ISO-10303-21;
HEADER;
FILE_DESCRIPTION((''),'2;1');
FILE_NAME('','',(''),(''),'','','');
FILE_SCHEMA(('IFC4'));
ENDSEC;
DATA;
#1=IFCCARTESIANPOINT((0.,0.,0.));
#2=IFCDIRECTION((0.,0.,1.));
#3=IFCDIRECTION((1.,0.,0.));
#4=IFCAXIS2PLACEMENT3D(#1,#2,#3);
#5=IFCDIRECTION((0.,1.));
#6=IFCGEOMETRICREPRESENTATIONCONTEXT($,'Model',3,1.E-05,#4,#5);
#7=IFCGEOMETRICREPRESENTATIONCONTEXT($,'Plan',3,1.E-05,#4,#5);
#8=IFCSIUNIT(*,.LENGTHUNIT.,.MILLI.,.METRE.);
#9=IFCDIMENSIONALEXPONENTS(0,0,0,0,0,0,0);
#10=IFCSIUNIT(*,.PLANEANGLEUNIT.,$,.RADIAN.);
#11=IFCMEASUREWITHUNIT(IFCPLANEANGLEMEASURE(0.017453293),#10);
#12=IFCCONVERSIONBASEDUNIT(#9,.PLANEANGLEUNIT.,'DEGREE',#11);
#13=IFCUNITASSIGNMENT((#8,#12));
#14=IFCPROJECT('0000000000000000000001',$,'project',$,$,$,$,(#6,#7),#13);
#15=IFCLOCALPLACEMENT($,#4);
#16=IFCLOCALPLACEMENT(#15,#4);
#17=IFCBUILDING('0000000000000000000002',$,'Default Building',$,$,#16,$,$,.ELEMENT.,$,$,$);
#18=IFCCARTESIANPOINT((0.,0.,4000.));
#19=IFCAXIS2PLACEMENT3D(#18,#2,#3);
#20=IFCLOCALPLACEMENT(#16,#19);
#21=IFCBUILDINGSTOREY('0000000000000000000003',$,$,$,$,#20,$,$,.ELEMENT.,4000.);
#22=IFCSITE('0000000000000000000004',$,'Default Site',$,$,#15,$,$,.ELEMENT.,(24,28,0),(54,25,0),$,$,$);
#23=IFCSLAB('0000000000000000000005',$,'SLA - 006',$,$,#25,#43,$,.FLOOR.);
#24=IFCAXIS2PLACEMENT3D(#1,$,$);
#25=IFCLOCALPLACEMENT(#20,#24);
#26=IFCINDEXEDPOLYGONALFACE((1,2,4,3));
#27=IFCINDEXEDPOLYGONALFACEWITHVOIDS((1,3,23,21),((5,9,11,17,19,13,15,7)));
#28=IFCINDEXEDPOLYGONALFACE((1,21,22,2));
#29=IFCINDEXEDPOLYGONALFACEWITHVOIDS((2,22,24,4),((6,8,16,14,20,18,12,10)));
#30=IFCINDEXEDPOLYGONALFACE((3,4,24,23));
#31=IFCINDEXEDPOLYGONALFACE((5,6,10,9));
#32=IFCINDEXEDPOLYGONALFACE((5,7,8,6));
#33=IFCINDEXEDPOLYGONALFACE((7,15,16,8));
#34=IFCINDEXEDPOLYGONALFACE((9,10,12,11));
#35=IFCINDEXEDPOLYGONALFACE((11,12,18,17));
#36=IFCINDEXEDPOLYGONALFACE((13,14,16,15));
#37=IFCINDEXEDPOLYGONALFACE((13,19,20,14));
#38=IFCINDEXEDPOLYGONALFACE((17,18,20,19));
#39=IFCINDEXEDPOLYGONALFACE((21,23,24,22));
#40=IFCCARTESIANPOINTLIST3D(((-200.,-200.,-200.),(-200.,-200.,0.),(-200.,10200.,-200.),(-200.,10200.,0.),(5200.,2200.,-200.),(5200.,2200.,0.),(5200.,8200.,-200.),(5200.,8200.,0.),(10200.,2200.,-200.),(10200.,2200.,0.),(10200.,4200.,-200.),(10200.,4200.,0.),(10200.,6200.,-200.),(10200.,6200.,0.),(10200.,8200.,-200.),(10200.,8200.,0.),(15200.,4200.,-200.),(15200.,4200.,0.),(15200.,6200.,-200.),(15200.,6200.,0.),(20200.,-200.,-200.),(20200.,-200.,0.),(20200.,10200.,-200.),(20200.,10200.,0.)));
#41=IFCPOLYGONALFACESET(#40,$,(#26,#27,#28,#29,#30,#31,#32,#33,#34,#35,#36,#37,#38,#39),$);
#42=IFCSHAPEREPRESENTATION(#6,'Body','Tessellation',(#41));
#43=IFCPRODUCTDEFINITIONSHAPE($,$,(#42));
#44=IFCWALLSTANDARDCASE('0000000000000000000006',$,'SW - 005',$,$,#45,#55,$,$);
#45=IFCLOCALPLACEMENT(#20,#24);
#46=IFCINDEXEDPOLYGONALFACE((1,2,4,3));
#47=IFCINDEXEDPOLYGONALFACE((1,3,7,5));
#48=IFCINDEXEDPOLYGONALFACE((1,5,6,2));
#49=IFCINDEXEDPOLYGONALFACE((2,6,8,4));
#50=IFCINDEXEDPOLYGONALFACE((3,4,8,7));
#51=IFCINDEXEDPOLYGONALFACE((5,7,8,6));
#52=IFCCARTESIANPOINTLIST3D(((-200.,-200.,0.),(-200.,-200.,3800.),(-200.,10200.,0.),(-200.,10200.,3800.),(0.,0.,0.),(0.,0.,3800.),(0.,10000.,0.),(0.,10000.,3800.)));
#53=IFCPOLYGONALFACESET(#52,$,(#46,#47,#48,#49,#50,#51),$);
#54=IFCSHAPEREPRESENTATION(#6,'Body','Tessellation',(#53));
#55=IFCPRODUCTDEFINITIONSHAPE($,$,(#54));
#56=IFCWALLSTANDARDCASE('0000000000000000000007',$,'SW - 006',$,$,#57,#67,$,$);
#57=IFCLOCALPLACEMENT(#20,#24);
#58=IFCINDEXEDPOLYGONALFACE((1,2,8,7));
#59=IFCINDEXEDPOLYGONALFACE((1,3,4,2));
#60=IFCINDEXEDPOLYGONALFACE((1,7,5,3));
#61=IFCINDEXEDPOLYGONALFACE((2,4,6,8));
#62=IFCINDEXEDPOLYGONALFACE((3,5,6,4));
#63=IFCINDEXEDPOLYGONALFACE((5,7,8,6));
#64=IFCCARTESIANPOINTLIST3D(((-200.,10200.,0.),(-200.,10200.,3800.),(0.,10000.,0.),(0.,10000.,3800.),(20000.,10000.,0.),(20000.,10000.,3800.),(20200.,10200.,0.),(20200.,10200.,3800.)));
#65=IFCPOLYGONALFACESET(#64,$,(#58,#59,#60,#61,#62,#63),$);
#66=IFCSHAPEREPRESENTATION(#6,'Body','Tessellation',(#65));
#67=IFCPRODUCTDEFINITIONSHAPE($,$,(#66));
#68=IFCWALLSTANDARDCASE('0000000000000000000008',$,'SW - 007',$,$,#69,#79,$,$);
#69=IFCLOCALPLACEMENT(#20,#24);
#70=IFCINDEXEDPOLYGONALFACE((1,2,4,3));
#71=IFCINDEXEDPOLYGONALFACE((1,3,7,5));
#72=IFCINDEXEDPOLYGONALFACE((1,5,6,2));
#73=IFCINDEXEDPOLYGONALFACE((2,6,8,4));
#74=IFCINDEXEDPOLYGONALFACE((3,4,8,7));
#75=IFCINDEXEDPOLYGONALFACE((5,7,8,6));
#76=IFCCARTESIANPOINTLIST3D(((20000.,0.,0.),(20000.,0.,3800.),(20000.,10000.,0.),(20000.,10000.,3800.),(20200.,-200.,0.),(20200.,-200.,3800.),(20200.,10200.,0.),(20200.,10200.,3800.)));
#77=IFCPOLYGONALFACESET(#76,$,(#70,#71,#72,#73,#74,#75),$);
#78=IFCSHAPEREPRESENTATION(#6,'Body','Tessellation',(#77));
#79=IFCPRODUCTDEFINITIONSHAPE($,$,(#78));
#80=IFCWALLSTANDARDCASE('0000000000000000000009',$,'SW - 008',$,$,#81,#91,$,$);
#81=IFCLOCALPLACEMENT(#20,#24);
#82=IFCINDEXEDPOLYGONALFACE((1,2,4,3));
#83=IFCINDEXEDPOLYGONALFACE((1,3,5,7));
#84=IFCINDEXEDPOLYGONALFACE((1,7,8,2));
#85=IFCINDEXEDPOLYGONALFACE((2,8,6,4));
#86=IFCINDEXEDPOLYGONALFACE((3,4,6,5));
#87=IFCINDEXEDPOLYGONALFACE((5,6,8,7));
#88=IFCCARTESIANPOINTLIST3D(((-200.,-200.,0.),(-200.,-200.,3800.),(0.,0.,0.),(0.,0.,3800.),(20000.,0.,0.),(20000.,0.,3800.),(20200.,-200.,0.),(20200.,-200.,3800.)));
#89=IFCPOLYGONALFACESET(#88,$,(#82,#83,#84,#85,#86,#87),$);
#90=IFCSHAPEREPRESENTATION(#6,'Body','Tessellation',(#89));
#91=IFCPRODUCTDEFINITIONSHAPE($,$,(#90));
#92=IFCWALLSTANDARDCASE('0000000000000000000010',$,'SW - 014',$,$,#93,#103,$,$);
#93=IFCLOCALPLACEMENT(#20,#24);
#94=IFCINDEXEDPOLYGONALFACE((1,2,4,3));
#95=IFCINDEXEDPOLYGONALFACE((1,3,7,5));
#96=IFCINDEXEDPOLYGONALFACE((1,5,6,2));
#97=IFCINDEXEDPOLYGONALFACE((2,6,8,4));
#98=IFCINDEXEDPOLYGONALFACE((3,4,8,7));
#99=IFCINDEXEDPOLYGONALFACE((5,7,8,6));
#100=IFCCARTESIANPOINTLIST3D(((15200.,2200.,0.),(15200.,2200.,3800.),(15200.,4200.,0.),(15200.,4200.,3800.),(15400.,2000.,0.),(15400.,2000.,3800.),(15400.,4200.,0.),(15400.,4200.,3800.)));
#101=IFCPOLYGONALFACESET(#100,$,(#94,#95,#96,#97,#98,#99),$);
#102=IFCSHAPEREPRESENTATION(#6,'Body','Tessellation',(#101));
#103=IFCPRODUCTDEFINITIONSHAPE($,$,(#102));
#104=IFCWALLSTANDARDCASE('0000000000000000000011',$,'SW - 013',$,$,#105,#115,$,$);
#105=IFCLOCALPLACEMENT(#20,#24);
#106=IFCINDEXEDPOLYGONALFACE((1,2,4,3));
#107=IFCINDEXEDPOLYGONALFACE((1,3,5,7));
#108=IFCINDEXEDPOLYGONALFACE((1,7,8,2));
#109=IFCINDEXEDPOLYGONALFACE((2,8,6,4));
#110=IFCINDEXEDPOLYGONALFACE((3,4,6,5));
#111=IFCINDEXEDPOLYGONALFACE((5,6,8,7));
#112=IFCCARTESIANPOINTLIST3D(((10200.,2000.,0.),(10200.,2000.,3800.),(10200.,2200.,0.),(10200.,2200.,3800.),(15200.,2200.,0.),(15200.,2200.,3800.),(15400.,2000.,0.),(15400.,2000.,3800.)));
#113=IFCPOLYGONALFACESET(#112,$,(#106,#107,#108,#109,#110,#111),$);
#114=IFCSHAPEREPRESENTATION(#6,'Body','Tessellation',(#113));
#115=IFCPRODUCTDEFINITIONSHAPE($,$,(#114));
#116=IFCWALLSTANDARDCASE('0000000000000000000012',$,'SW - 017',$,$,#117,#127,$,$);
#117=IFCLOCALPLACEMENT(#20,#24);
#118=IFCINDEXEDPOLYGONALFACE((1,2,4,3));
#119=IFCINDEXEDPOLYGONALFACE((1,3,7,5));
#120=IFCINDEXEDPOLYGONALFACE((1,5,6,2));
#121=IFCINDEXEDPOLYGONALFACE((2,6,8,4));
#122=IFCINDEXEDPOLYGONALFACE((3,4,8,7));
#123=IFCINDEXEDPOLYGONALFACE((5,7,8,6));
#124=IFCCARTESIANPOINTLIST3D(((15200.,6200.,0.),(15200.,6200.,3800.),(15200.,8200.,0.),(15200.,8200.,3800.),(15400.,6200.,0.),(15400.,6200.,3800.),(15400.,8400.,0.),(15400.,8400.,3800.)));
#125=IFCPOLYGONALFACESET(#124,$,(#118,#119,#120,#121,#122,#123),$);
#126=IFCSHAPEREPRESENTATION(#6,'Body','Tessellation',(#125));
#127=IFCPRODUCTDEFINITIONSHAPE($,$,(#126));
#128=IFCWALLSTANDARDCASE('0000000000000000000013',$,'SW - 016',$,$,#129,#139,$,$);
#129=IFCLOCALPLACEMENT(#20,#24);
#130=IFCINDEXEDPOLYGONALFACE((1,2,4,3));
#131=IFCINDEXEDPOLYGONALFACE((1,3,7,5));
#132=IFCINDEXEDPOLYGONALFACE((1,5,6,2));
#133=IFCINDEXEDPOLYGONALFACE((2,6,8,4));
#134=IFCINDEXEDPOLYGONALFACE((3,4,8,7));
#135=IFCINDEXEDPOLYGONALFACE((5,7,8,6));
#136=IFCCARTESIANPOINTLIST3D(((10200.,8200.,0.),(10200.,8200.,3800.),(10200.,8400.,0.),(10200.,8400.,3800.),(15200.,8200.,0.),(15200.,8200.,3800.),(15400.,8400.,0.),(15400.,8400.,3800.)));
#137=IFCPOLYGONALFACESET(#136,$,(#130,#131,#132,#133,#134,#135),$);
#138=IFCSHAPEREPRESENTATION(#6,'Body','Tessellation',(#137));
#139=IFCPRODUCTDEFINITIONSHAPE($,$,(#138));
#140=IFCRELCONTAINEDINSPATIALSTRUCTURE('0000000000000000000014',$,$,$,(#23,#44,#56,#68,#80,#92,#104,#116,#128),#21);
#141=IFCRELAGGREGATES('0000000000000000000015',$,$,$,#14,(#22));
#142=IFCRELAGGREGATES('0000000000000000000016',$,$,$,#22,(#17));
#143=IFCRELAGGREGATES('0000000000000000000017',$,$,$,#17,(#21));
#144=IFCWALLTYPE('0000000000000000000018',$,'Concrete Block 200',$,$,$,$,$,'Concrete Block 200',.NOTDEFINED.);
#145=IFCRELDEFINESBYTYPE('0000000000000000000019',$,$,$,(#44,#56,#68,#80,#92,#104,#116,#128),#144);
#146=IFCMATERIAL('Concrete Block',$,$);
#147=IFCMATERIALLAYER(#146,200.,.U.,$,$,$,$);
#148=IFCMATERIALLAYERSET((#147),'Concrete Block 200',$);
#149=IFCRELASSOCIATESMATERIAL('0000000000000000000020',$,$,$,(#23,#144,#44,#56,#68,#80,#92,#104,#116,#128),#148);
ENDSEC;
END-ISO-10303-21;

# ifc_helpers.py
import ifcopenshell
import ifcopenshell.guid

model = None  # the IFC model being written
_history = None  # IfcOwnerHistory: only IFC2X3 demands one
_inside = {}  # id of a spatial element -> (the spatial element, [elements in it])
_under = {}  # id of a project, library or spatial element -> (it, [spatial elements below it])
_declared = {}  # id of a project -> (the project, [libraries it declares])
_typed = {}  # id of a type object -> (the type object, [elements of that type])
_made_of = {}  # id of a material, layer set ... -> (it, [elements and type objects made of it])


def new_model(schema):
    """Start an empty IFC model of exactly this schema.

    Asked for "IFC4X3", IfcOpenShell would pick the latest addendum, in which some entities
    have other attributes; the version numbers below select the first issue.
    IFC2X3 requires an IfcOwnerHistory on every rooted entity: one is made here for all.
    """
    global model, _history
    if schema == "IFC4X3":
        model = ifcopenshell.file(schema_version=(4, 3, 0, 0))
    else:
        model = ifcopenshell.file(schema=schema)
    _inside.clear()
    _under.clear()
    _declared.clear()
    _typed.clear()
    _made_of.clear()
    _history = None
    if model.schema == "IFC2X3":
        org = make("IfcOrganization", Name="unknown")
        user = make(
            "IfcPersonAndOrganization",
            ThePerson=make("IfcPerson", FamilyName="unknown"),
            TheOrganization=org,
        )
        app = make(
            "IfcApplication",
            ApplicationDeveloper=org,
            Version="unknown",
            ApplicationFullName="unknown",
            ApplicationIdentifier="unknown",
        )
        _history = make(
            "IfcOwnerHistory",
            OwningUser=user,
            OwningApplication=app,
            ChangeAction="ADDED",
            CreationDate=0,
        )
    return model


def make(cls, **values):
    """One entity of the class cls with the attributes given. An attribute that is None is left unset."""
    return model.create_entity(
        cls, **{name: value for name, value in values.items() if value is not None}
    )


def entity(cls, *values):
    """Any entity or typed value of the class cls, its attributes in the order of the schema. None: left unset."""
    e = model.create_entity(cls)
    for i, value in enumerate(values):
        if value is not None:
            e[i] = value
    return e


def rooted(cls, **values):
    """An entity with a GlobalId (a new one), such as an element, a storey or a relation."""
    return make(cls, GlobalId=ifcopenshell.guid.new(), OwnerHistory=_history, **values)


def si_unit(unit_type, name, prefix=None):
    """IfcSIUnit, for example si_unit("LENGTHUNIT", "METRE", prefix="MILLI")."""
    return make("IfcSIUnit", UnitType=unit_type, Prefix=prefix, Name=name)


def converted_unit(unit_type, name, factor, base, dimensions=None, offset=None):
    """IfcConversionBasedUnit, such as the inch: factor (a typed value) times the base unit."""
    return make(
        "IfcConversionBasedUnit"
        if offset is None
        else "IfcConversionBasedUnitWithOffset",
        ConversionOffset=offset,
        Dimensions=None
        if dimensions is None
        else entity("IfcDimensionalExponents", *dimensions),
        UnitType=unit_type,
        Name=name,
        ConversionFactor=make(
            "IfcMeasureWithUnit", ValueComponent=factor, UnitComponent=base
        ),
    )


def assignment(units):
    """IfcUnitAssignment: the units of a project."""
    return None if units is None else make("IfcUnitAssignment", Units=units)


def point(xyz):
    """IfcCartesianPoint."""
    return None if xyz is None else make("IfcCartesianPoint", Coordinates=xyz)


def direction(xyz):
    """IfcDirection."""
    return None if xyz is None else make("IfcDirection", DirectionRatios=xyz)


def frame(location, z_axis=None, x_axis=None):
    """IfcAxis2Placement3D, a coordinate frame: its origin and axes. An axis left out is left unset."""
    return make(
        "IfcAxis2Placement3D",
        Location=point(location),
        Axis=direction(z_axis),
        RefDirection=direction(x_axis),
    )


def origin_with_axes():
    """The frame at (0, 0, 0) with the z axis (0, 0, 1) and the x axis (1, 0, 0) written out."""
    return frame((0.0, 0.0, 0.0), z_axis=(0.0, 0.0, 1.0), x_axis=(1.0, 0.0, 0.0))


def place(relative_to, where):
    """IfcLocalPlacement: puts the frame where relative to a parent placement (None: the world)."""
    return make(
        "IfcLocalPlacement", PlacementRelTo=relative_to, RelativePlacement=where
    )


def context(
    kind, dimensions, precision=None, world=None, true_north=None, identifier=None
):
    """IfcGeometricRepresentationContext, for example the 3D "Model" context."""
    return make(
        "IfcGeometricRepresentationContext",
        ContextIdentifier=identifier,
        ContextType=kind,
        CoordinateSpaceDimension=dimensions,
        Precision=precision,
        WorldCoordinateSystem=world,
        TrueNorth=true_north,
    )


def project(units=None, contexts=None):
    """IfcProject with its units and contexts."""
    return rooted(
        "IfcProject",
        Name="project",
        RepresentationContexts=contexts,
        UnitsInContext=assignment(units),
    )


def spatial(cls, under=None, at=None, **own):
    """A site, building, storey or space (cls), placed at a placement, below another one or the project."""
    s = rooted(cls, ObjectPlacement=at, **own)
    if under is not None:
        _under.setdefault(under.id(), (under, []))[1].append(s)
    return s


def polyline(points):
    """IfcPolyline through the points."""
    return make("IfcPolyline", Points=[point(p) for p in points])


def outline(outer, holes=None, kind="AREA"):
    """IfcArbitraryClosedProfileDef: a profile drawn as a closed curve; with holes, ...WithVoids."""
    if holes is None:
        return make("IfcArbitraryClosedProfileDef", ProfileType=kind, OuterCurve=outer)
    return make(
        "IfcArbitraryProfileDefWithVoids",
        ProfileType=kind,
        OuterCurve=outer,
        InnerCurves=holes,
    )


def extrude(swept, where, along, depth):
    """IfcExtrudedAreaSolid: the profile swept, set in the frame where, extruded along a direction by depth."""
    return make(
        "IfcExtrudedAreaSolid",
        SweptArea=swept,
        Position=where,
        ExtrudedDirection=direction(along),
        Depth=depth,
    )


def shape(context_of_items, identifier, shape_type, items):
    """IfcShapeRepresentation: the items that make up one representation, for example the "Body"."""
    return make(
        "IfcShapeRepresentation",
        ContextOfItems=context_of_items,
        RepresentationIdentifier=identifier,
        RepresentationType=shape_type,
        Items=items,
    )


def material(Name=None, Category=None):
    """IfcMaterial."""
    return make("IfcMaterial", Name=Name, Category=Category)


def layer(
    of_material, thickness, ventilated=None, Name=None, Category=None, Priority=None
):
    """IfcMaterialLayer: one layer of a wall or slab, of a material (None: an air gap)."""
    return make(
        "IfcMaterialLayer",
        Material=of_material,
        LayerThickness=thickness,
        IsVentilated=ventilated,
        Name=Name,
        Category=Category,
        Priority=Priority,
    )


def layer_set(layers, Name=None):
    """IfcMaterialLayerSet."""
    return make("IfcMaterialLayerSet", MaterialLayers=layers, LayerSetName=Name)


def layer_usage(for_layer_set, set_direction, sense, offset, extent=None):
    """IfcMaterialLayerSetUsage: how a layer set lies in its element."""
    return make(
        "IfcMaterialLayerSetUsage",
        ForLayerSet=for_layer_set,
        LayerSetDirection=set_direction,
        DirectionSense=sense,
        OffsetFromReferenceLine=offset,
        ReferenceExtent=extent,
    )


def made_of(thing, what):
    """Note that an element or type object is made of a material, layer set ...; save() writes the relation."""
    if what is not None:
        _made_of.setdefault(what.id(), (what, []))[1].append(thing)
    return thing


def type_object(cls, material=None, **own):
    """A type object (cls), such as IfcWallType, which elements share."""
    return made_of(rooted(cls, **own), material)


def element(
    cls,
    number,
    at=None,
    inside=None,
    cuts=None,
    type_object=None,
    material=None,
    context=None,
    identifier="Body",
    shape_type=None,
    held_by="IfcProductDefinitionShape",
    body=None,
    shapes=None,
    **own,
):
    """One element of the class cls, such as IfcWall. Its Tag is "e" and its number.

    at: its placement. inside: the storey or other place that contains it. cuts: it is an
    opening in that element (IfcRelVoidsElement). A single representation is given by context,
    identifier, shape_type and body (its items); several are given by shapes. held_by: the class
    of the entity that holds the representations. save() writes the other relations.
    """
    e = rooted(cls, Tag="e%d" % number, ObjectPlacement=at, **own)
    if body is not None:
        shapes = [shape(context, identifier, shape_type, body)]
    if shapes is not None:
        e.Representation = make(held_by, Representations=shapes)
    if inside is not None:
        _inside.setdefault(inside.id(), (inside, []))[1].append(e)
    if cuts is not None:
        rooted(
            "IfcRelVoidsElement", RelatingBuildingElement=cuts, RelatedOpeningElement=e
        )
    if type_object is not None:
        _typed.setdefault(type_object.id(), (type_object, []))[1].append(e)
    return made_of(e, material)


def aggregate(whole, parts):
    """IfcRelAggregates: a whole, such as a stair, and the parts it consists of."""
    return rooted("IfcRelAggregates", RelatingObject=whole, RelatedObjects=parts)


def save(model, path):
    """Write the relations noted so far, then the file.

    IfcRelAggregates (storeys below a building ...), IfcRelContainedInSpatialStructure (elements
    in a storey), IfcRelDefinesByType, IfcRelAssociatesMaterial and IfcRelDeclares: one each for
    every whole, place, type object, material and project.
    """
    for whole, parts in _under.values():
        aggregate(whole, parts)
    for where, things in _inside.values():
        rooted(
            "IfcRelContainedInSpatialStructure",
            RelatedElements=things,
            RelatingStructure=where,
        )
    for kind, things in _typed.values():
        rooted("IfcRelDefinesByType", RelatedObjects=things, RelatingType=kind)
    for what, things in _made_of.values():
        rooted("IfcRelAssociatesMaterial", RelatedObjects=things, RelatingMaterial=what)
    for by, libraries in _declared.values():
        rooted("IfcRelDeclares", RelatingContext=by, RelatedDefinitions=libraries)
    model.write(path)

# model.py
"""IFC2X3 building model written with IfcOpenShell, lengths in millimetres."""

from ifc_helpers import new_model, entity, si_unit, converted_unit, direction, frame, origin_with_axes, place, context, project, spatial, polyline, outline, extrude, material, layer, layer_set, layer_usage, type_object, element, save


model = new_model("IFC2X3")

# Units and contexts
model_context = context("Model", 3, precision=1e-05, world=origin_with_axes(), true_north=direction((0.0, 1.0)))
plan_context = context("Plan", 3, precision=1e-05, world=origin_with_axes(), true_north=direction((0.0, 1.0)))
ifc_project = project(units=[si_unit("LENGTHUNIT", "METRE", prefix="MILLI"), converted_unit("PLANEANGLEUNIT", "DEGREE", entity("IfcPlaneAngleMeasure", 0.017453293), si_unit("PLANEANGLEUNIT", "RADIAN"), dimensions=[0, 0, 0, 0, 0, 0, 0])], contexts=[model_context, plan_context])

# Site, building, storey
site_placement = place(None, origin_with_axes())
site = spatial("IfcSite", under=ifc_project, at=site_placement, Name="Default Site", CompositionType="ELEMENT", RefLatitude=(24, 28, 0), RefLongitude=(54, 25, 0))
building_placement = place(site_placement, origin_with_axes())
building = spatial("IfcBuilding", under=site, at=building_placement, Name="Default Building", CompositionType="ELEMENT")
storey_placement = place(building_placement, frame((0.0, 0.0, 4000.0), z_axis=(0.0, 0.0, 1.0), x_axis=(1.0, 0.0, 0.0)))
storey = spatial("IfcBuildingStorey", under=building, at=storey_placement, CompositionType="ELEMENT", Elevation=4000.0)

# Slab, opening
ifc_material = material(Name="Concrete Block")
ifc_layer = layer(ifc_material, 200.0, ventilated="UNKNOWN")
ifc_layer_set = layer_set([ifc_layer], Name="Concrete Block 200")
ifc_layer_usage_1 = layer_usage(ifc_layer_set, "AXIS3", "NEGATIVE", 200.0)
slab_placement = place(storey_placement, frame((20200.0, 10200.0, -200.0), z_axis=(0.0, 0.0, 1.0), x_axis=(-1.0, 0.0, 0.0)))
slab = element("IfcSlab", 1, at=slab_placement, inside=storey, material=ifc_layer_usage_1, Name="SLA - 006", PredefinedType="FLOOR", context=model_context, shape_type="SweptSolid", body=[
    extrude(outline(polyline([(0.0, 0.0), (20400.0, 0.0), (20400.0, 10400.0), (0.0, 10400.0), (0.0, 0.0)])), origin_with_axes(), (0.0, 0.0, 1.0), 200.0),
])
opening_placement = place(slab_placement, origin_with_axes())
element("IfcOpeningElement", 2, at=opening_placement, cuts=slab, context=model_context, shape_type="SweptSolid", body=[
    extrude(outline(polyline([(10000.0, 8000.0), (15000.0, 8000.0), (15000.0, 2000.0), (10000.0, 2000.0), (10000.0, 4000.0), (5000.0, 4000.0), (5000.0, 6000.0), (10000.0, 6000.0), (10000.0, 8000.0)])), origin_with_axes(), (0.0, 0.0, 1.0), 200.0),
])

# Walls
ifc_layer_usage_2 = layer_usage(ifc_layer_set, "AXIS2", "POSITIVE", 0.0)
wall_type = type_object("IfcWallType", Name="Concrete Block 200", ElementType="Concrete Block 200", PredefinedType="NOTDEFINED", material=ifc_layer_set)
wall_1_placement = place(storey_placement, frame((0.0, 0.0, 0.0), z_axis=(0.0, 0.0, 1.0), x_axis=(0.0, 1.0, 0.0)))
element("IfcWallStandardCase", 3, at=wall_1_placement, inside=storey, type_object=wall_type, material=ifc_layer_usage_2, Name="SW - 005", context=model_context, shape_type="SweptSolid", body=[
    extrude(outline(polyline([(0.0, 0.0), (10000.0, 0.0), (10200.0, 200.0), (-200.0, 200.0), (0.0, 0.0)])), origin_with_axes(), (0.0, 0.0, 1.0), 3800.0),
])
ifc_layer_usage_3 = layer_usage(ifc_layer_set, "AXIS2", "POSITIVE", 0.0)
wall_2_placement = place(storey_placement, frame((0.0, 10000.0, 0.0), z_axis=(0.0, 0.0, 1.0), x_axis=(1.0, 0.0, 0.0)))
element("IfcWallStandardCase", 4, at=wall_2_placement, inside=storey, type_object=wall_type, material=ifc_layer_usage_3, Name="SW - 006", context=model_context, shape_type="SweptSolid", body=[
    extrude(outline(polyline([(0.0, 0.0), (20000.0, 0.0), (20200.0, 200.0), (-200.0, 200.0), (0.0, 0.0)])), origin_with_axes(), (0.0, 0.0, 1.0), 3800.0),
])
ifc_layer_usage_4 = layer_usage(ifc_layer_set, "AXIS2", "POSITIVE", 0.0)
wall_3_placement = place(storey_placement, frame((20000.0, 10000.0, 0.0), z_axis=(0.0, 0.0, 1.0), x_axis=(0.0, -1.0, 0.0)))
element("IfcWallStandardCase", 5, at=wall_3_placement, inside=storey, type_object=wall_type, material=ifc_layer_usage_4, Name="SW - 007", context=model_context, shape_type="SweptSolid", body=[
    extrude(outline(polyline([(0.0, 0.0), (10000.0, 0.0), (10200.0, 200.0), (-200.0, 200.0), (0.0, 0.0)])), origin_with_axes(), (0.0, 0.0, 1.0), 3800.0),
])
ifc_layer_usage_5 = layer_usage(ifc_layer_set, "AXIS2", "POSITIVE", 0.0)
wall_4_placement = place(storey_placement, frame((20000.0, 0.0, 0.0), z_axis=(0.0, 0.0, 1.0), x_axis=(-1.0, 0.0, 0.0)))
element("IfcWallStandardCase", 6, at=wall_4_placement, inside=storey, type_object=wall_type, material=ifc_layer_usage_5, Name="SW - 008", context=model_context, shape_type="SweptSolid", body=[
    extrude(outline(polyline([(0.0, 0.0), (20000.0, 0.0), (20200.0, 200.0), (-200.0, 200.0), (0.0, 0.0)])), origin_with_axes(), (0.0, 0.0, 1.0), 3800.0),
])
ifc_layer_usage_6 = layer_usage(ifc_layer_set, "AXIS2", "POSITIVE", 0.0)
wall_5_placement = place(storey_placement, frame((15400.0, 2000.0, 0.0), z_axis=(0.0, 0.0, 1.0), x_axis=(0.0, 1.0, 0.0)))
element("IfcWallStandardCase", 7, at=wall_5_placement, inside=storey, type_object=wall_type, material=ifc_layer_usage_6, Name="SW - 014", context=model_context, shape_type="SweptSolid", body=[
    extrude(outline(polyline([(0.0, 0.0), (2200.0, 0.0), (2200.0, 200.0), (200.0, 200.0), (0.0, 0.0)])), origin_with_axes(), (0.0, 0.0, 1.0), 3800.0),
])
ifc_layer_usage_7 = layer_usage(ifc_layer_set, "AXIS2", "POSITIVE", 0.0)
wall_6_placement = place(storey_placement, frame((10200.0, 2000.0, 0.0), z_axis=(0.0, 0.0, 1.0), x_axis=(1.0, 0.0, 0.0)))
element("IfcWallStandardCase", 8, at=wall_6_placement, inside=storey, type_object=wall_type, material=ifc_layer_usage_7, Name="SW - 013", context=model_context, shape_type="SweptSolid", body=[
    extrude(outline(polyline([(0.0, 0.0), (5200.0, 0.0), (5000.0, 200.0), (0.0, 200.0), (0.0, 0.0)])), origin_with_axes(), (0.0, 0.0, 1.0), 3800.0),
])
ifc_layer_usage_8 = layer_usage(ifc_layer_set, "AXIS2", "POSITIVE", 0.0)
wall_7_placement = place(storey_placement, frame((15400.0, 6200.0, 0.0), z_axis=(0.0, 0.0, 1.0), x_axis=(0.0, 1.0, 0.0)))
element("IfcWallStandardCase", 9, at=wall_7_placement, inside=storey, type_object=wall_type, material=ifc_layer_usage_8, Name="SW - 017", context=model_context, shape_type="SweptSolid", body=[
    extrude(outline(polyline([(0.0, 0.0), (2200.0, 0.0), (2000.0, 200.0), (0.0, 200.0), (0.0, 0.0)])), origin_with_axes(), (0.0, 0.0, 1.0), 3800.0),
])
ifc_layer_usage_9 = layer_usage(ifc_layer_set, "AXIS2", "NEGATIVE", 0.0)
wall_8_placement = place(storey_placement, frame((10200.0, 8400.0, 0.0), z_axis=(0.0, 0.0, 1.0), x_axis=(1.0, 0.0, 0.0)))
element("IfcWallStandardCase", 10, at=wall_8_placement, inside=storey, type_object=wall_type, material=ifc_layer_usage_9, Name="SW - 016", context=model_context, shape_type="SweptSolid", body=[
    extrude(outline(polyline([(0.0, -200.0), (5000.0, -200.0), (5200.0, 0.0), (0.0, 0.0), (0.0, -200.0)])), origin_with_axes(), (0.0, 0.0, 1.0), 3800.0),
])

save(model, "model.ifc")
